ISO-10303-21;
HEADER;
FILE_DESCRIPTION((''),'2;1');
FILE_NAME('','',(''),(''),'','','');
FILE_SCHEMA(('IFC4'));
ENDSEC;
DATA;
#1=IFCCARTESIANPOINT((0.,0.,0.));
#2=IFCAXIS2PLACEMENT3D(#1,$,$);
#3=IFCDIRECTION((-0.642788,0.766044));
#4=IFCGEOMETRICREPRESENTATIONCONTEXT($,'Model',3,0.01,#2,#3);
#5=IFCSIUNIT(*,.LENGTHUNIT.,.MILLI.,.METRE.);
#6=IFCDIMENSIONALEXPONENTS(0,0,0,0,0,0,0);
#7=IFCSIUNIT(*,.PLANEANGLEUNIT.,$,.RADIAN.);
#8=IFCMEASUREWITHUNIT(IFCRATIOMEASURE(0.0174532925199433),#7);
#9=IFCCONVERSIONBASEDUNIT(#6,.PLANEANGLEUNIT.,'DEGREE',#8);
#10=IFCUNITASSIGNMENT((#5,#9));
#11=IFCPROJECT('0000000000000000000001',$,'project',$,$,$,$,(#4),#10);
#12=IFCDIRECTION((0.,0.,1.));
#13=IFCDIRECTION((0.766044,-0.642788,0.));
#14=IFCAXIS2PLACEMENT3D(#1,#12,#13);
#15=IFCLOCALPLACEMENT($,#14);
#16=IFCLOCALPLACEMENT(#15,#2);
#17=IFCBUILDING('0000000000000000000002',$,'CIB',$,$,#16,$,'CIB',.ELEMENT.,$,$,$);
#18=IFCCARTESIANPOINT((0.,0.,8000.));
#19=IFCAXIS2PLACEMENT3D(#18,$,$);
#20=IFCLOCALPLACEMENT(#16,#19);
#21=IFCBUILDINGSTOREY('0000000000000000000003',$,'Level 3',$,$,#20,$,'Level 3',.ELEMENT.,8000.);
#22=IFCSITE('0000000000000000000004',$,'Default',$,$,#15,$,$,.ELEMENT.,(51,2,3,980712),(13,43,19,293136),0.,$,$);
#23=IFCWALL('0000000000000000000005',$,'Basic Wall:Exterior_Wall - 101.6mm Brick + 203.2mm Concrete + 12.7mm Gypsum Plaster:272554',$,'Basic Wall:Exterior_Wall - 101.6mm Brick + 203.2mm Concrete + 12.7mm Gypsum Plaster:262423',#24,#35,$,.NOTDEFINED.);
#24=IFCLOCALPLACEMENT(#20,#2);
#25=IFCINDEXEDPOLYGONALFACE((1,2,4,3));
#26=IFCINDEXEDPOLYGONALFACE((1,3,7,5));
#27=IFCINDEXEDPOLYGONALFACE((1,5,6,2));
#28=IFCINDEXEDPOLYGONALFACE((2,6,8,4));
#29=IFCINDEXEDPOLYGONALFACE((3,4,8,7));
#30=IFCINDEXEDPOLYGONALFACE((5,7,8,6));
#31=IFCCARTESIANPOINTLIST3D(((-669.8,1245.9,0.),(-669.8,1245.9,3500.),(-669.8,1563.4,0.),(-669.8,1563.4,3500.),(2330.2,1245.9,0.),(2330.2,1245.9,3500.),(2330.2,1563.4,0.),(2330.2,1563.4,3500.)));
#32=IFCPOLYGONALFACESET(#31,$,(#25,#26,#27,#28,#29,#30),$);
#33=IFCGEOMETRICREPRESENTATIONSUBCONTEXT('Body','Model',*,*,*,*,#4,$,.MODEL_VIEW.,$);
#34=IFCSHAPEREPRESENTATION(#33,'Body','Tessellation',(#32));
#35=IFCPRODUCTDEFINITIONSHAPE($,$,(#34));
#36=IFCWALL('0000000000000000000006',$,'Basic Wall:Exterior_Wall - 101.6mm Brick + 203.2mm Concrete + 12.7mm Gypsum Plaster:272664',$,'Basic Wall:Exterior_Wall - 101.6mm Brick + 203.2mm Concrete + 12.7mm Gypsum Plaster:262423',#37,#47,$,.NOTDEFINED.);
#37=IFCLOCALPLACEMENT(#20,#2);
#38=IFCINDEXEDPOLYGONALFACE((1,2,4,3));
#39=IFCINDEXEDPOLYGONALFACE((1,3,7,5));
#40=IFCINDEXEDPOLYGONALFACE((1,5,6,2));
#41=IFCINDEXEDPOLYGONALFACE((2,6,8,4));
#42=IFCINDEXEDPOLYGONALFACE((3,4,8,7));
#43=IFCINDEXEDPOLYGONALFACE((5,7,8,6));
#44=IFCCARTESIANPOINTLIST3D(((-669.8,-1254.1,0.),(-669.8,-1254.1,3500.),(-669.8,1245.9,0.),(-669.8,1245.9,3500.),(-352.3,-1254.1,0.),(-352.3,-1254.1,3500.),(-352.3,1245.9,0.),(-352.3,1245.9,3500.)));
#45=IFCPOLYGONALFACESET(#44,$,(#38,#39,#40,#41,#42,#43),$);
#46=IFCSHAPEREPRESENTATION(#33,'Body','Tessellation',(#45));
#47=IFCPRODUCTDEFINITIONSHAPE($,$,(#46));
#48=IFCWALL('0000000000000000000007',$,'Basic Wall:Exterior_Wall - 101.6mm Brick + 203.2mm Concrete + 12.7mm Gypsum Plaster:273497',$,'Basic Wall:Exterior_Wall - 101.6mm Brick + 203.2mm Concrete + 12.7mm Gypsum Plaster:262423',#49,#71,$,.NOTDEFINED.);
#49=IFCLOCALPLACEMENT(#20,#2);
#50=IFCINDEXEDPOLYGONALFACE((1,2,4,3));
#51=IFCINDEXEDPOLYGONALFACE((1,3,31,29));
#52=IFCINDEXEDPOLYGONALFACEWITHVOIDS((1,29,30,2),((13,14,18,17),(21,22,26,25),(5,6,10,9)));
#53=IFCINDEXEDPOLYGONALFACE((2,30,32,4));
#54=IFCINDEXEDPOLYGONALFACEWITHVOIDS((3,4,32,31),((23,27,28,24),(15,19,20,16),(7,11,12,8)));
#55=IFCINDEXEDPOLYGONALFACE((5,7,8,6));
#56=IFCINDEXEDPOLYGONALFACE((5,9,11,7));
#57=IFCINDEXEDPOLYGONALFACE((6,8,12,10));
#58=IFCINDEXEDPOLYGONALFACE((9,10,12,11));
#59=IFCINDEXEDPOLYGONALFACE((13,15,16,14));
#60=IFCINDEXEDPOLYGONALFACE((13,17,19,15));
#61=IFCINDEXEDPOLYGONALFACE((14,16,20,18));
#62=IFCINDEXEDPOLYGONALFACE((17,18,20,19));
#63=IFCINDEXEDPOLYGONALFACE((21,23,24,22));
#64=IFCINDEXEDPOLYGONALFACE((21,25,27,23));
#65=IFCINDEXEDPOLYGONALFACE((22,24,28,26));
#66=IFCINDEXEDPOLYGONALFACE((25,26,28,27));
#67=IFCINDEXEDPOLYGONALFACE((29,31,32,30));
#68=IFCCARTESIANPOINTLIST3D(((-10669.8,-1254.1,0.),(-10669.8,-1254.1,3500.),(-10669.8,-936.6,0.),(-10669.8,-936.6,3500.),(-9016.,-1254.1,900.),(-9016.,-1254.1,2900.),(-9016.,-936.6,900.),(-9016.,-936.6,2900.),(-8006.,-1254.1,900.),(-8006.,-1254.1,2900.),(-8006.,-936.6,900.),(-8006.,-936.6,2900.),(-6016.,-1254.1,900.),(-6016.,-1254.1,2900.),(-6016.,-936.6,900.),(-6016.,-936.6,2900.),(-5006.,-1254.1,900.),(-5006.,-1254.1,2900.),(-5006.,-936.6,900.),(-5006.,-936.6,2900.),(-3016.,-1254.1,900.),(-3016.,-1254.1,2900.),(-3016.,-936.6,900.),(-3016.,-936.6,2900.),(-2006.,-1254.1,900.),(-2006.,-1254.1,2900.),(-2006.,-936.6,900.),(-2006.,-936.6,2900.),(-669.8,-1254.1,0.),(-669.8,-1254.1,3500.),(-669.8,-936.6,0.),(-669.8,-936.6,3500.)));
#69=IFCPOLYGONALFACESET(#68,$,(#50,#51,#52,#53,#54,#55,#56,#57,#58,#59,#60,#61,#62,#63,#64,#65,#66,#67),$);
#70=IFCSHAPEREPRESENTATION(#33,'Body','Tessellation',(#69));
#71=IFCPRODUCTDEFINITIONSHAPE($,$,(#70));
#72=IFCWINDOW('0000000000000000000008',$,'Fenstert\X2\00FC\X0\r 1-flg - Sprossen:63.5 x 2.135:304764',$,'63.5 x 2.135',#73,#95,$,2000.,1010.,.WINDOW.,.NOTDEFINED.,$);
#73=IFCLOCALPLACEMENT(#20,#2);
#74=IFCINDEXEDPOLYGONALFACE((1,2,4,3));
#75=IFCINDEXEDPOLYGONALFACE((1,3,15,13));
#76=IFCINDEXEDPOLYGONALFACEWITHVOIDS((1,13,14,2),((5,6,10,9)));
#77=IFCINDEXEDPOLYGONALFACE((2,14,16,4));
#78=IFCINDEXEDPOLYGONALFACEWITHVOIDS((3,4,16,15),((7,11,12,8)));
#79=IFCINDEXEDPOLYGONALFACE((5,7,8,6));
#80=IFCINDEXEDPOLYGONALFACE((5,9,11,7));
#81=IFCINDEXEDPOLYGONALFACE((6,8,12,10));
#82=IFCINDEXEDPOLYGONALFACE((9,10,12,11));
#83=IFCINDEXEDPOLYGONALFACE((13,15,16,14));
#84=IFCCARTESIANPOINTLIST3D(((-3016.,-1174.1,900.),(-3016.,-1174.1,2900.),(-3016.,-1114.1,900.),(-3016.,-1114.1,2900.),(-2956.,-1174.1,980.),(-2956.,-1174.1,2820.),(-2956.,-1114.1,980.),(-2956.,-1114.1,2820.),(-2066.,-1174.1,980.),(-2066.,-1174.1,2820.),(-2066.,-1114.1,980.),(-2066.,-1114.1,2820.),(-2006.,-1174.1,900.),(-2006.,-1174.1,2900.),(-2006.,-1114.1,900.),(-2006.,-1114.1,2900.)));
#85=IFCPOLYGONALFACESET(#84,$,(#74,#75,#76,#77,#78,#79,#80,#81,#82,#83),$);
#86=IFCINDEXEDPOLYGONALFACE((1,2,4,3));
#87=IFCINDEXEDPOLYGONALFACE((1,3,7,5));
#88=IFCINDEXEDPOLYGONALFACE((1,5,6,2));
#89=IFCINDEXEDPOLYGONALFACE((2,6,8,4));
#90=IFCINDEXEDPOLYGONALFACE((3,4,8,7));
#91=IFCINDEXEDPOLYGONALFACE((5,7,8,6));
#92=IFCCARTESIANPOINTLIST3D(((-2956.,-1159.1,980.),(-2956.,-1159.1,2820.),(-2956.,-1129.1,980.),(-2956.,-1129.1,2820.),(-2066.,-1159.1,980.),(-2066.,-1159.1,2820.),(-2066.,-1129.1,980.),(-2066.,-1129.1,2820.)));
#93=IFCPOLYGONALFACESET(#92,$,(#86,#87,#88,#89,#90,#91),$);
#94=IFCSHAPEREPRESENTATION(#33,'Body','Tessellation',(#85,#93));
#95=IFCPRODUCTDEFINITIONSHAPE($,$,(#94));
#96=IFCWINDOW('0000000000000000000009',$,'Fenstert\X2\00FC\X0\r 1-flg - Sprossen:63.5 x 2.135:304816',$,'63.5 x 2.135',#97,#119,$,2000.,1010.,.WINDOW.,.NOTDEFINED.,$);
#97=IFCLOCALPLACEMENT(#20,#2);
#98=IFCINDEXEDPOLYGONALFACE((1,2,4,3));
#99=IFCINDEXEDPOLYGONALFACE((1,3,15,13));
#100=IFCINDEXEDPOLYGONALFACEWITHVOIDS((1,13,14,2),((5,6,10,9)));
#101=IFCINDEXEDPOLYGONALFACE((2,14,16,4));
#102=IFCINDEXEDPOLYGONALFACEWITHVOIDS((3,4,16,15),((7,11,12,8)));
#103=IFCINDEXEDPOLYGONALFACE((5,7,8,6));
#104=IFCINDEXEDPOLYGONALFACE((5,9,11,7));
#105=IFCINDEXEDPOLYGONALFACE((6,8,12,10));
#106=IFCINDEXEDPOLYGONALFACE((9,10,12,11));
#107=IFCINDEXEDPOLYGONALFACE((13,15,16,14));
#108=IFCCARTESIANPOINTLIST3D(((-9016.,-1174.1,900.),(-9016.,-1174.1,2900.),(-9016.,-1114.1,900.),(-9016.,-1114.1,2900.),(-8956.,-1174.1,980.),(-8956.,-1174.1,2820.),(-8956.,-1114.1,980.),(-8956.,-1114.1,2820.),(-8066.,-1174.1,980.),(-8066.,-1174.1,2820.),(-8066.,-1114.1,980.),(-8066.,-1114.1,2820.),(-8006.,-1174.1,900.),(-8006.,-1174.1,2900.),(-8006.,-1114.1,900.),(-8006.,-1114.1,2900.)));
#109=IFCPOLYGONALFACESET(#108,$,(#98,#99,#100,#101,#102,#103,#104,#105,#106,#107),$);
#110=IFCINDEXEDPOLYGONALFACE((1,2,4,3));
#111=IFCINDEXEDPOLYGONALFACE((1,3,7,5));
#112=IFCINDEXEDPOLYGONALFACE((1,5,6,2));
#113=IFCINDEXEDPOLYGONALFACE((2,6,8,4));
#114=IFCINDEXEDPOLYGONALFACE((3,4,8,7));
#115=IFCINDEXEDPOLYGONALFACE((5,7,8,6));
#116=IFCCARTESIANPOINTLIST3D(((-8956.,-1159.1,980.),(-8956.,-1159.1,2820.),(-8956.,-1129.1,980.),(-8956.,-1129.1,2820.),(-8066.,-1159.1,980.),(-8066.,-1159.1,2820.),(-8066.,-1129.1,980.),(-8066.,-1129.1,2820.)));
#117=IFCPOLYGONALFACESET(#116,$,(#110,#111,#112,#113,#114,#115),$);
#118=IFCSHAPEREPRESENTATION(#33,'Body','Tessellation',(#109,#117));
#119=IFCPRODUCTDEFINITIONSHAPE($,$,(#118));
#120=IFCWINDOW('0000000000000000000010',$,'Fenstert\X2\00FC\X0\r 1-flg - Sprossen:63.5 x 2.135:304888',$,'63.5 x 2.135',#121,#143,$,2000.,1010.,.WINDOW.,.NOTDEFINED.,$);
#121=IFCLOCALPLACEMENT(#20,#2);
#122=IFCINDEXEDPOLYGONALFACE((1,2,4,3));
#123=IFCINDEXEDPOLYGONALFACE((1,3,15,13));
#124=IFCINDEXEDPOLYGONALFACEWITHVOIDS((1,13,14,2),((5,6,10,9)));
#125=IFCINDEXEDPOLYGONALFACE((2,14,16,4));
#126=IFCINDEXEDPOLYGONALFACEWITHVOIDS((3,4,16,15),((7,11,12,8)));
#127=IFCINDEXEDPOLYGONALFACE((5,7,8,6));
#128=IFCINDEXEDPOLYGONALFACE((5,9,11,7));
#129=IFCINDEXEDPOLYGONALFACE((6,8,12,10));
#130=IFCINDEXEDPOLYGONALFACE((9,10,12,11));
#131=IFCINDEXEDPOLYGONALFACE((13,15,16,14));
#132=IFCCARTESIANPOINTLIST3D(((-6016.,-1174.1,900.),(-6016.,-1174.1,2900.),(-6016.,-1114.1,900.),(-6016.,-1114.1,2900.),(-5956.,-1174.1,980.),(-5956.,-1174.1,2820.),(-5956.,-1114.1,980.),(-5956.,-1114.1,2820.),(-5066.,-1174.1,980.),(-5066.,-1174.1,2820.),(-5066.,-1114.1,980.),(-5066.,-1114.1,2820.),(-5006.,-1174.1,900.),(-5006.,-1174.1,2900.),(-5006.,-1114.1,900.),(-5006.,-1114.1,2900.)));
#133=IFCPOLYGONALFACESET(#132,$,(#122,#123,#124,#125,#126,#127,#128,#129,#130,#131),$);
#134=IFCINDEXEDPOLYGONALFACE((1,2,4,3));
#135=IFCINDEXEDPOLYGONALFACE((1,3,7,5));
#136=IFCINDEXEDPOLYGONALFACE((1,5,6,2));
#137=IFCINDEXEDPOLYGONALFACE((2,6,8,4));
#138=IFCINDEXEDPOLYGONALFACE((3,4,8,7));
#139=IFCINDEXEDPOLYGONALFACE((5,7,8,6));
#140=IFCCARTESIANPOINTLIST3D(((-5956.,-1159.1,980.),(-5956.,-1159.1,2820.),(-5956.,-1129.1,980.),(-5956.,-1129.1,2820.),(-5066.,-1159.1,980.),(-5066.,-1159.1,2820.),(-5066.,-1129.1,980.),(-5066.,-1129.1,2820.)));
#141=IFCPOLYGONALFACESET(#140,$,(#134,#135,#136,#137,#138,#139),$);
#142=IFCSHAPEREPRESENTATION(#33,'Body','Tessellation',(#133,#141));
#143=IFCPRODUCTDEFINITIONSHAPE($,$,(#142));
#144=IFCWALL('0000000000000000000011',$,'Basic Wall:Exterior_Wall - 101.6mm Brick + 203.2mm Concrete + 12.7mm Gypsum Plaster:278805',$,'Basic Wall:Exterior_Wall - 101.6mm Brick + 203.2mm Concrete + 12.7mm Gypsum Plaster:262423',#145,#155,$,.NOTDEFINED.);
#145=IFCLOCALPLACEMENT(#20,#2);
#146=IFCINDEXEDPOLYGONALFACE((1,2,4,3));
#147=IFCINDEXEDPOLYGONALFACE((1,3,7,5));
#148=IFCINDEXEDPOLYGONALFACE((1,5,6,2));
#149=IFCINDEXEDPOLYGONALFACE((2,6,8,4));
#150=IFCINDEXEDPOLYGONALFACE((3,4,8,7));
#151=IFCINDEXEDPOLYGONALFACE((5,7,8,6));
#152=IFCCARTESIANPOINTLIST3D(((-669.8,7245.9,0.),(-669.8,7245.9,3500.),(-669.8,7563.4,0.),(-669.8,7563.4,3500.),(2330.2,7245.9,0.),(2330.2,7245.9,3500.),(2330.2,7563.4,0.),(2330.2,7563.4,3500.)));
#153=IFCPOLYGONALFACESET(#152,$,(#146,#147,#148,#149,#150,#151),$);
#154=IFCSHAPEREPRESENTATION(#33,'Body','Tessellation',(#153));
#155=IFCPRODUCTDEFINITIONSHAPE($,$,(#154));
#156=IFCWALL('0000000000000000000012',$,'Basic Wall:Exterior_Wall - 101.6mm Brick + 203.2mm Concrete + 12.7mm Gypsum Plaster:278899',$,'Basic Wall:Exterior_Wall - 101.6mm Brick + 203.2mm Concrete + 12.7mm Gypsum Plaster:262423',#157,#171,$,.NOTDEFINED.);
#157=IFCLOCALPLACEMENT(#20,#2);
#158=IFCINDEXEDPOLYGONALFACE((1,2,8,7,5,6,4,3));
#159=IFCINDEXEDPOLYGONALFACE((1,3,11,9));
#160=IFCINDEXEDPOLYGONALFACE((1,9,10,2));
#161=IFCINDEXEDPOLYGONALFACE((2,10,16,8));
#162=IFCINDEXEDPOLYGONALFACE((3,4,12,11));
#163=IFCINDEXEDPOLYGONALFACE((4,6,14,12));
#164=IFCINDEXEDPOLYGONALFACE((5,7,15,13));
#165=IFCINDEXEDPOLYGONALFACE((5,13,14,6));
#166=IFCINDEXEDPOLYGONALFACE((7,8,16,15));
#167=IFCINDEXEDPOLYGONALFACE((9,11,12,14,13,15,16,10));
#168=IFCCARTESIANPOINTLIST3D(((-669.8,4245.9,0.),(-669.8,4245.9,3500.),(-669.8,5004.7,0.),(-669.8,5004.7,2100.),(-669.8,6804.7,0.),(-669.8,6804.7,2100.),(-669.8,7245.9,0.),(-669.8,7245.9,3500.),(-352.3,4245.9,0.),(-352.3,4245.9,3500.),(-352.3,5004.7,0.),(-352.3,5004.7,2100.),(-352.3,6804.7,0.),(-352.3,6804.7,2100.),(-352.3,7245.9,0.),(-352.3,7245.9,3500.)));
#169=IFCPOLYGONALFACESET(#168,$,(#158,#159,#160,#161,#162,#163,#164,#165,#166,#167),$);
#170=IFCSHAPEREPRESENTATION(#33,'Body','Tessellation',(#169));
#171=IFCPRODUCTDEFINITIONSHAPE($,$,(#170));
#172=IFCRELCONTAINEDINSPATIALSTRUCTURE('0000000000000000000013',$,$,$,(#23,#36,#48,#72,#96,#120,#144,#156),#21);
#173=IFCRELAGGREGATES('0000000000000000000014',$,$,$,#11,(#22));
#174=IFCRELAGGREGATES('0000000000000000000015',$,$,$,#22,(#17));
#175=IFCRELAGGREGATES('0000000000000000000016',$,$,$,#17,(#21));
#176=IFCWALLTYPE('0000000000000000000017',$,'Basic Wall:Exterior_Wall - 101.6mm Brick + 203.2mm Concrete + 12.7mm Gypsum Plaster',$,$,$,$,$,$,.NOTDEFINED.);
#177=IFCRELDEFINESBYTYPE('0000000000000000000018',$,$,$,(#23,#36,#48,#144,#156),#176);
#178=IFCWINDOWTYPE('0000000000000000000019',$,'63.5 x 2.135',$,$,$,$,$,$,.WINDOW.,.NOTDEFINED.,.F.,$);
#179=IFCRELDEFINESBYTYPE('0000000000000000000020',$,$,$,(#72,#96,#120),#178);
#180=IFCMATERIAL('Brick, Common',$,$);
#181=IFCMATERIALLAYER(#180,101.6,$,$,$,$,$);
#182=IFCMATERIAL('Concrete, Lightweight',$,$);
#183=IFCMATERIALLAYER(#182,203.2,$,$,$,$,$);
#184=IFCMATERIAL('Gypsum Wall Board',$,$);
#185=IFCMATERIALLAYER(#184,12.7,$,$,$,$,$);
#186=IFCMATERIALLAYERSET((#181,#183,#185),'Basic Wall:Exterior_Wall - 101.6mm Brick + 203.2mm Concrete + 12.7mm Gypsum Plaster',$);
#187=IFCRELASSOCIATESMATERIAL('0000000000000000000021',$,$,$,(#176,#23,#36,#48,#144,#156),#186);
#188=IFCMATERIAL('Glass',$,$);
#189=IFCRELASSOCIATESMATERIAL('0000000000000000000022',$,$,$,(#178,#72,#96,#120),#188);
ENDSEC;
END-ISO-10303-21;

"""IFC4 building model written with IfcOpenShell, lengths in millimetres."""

from ifc_helpers import new_model, entity, si_unit, converted_unit, direction, frame, frame_2d, origin, origin_2d_with_axis, place, context, subcontext, project, spatial, polyline, rectangle, outline, extrude, source, transform, mapped, material, layer, layer_set, layer_usage, type_object, type_shapes, element, fill, save


model = new_model("IFC4")

# Units and contexts
model_context = context("Model", 3, precision=0.01, world=origin(), true_north=direction((-0.642788, 0.766044)))
body_context = subcontext(model_context, "Body", "Model", "MODEL_VIEW")
ifc_project = project(units=[si_unit("LENGTHUNIT", "METRE", prefix="MILLI"), converted_unit("PLANEANGLEUNIT", "DEGREE", entity("IfcRatioMeasure", 0.0174532925199433), si_unit("PLANEANGLEUNIT", "RADIAN"), dimensions=[0, 0, 0, 0, 0, 0, 0])], contexts=[model_context])

# Site, building, storey
site_placement = place(None, frame((0.0, 0.0, 0.0), z_axis=(0.0, 0.0, 1.0), x_axis=(0.766044, -0.642788, 0.0)))
site = spatial("IfcSite", under=ifc_project, at=site_placement, Name="Default", CompositionType="ELEMENT", RefLatitude=(51, 2, 3, 980712), RefLongitude=(13, 43, 19, 293136), RefElevation=0.0)
building_placement = place(site_placement, origin())
building = spatial("IfcBuilding", under=site, at=building_placement, Name="CIB", LongName="CIB", CompositionType="ELEMENT")
storey_placement = place(building_placement, frame((0.0, 0.0, 8000.0)))
storey = spatial("IfcBuildingStorey", under=building, at=storey_placement, Name="Level 3", LongName="Level 3", CompositionType="ELEMENT", Elevation=8000.0)

# Walls
ifc_material_1 = material(Name="Brick, Common")
ifc_layer_1 = layer(ifc_material_1, 101.6)
ifc_material_2 = material(Name="Concrete, Lightweight")
ifc_layer_2 = layer(ifc_material_2, 203.2)
ifc_material_3 = material(Name="Gypsum Wall Board")
ifc_layer_3 = layer(ifc_material_3, 12.7)
ifc_layer_set_1 = layer_set([ifc_layer_1, ifc_layer_2, ifc_layer_3], Name="Basic Wall:Exterior_Wall - 101.6mm Brick + 203.2mm Concrete + 12.7mm Gypsum Plaster")
ifc_layer_usage_1 = layer_usage(ifc_layer_set_1, "AXIS2", "NEGATIVE", 158.8)
wall_type_1 = type_object("IfcWallType", Name="Basic Wall:Exterior_Wall - 101.6mm Brick + 203.2mm Concrete + 12.7mm Gypsum Plaster", PredefinedType="NOTDEFINED", material=ifc_layer_set_1)
wall_1_placement = place(storey_placement, frame((2330.2, 1404.7, 0.0), z_axis=(0.0, 0.0, 1.0), x_axis=(-1.0, 0.0, 0.0)))
element("IfcWall", 1, at=wall_1_placement, inside=storey, type_object=wall_type_1, material=ifc_layer_usage_1, Name="Basic Wall:Exterior_Wall - 101.6mm Brick + 203.2mm Concrete + 12.7mm Gypsum Plaster:272554", ObjectType="Basic Wall:Exterior_Wall - 101.6mm Brick + 203.2mm Concrete + 12.7mm Gypsum Plaster:262423", PredefinedType="NOTDEFINED", context=body_context, shape_type="SweptSolid", body=[
    extrude(rectangle(XDim=3000.0, YDim=317.5, at=frame_2d((1500.0, 0.0), x_axis=(-1.0, 0.0))), origin(), (0.0, 0.0, 1.0), 3500.0),
])
ifc_layer_usage_2 = layer_usage(ifc_layer_set_1, "AXIS2", "NEGATIVE", 158.8)
wall_2_placement = place(storey_placement, frame((-511.0, 1245.9, 0.0), z_axis=(0.0, 0.0, 1.0), x_axis=(0.0, -1.0, 0.0)))
element("IfcWall", 2, at=wall_2_placement, inside=storey, type_object=wall_type_1, material=ifc_layer_usage_2, Name="Basic Wall:Exterior_Wall - 101.6mm Brick + 203.2mm Concrete + 12.7mm Gypsum Plaster:272664", ObjectType="Basic Wall:Exterior_Wall - 101.6mm Brick + 203.2mm Concrete + 12.7mm Gypsum Plaster:262423", PredefinedType="NOTDEFINED", context=body_context, shape_type="SweptSolid", body=[
    extrude(rectangle(XDim=2500.0, YDim=317.5, at=frame_2d((1250.0, 0.0), x_axis=(-1.0, 0.0))), origin(), (0.0, 0.0, 1.0), 3500.0),
])

# Wall, openings, windows
ifc_layer_usage_3 = layer_usage(ifc_layer_set_1, "AXIS2", "NEGATIVE", 158.8)
wall_3_placement = place(storey_placement, frame((-669.8, -1095.3, 0.0), z_axis=(0.0, 0.0, 1.0), x_axis=(-1.0, 0.0, 0.0)))
wall_3 = element("IfcWall", 3, at=wall_3_placement, inside=storey, type_object=wall_type_1, material=ifc_layer_usage_3, Name="Basic Wall:Exterior_Wall - 101.6mm Brick + 203.2mm Concrete + 12.7mm Gypsum Plaster:273497", ObjectType="Basic Wall:Exterior_Wall - 101.6mm Brick + 203.2mm Concrete + 12.7mm Gypsum Plaster:262423", PredefinedType="NOTDEFINED", context=body_context, shape_type="SweptSolid", body=[
    extrude(rectangle(XDim=10000.0, YDim=317.5, at=frame_2d((5000.0, 0.0), x_axis=(-1.0, 0.0))), origin(), (0.0, 0.0, 1.0), 3500.0),
])
opening_1_placement = place(wall_3_placement, frame((2346.2, 158.7, 900.0)))
opening_1 = element("IfcOpeningElement", 4, at=opening_1_placement, cuts=wall_3, ObjectType="Opening", PredefinedType="OPENING", context=body_context, shape_type="SweptSolid", body=[
    extrude(rectangle(XDim=2000.0, YDim=1010.0, at=frame_2d((1000.0, 505.0), x_axis=(1.0, 0.0))), frame((0.0, 0.0, 0.0), z_axis=(0.0, -1.0, 0.0), x_axis=(0.0, 0.0, 1.0)), (0.0, 0.0, 1.0), 317.5),
])
opening_2_placement = place(wall_3_placement, frame((8346.2, 158.7, 900.0)))
opening_2 = element("IfcOpeningElement", 5, at=opening_2_placement, cuts=wall_3, ObjectType="Opening", PredefinedType="OPENING", context=body_context, shape_type="SweptSolid", body=[
    extrude(rectangle(XDim=2000.0, YDim=1010.0, at=frame_2d((1000.0, 505.0), x_axis=(1.0, 0.0))), frame((0.0, 0.0, 0.0), z_axis=(0.0, -1.0, 0.0), x_axis=(0.0, 0.0, 1.0)), (0.0, 0.0, 1.0), 317.5),
])
opening_3_placement = place(wall_3_placement, frame((5346.2, 158.7, 900.0)))
opening_3 = element("IfcOpeningElement", 6, at=opening_3_placement, cuts=wall_3, ObjectType="Opening", PredefinedType="OPENING", context=body_context, shape_type="SweptSolid", body=[
    extrude(rectangle(XDim=2000.0, YDim=1010.0, at=frame_2d((1000.0, 505.0), x_axis=(1.0, 0.0))), frame((0.0, 0.0, 0.0), z_axis=(0.0, -1.0, 0.0), x_axis=(0.0, 0.0, 1.0)), (0.0, 0.0, 1.0), 317.5),
])
ifc_material_4 = material(Name="Glass")
window_type = type_object("IfcWindowType", Name="63.5 x 2.135", ParameterTakesPrecedence=False, PartitioningType="NOTDEFINED", PredefinedType="WINDOW", material=ifc_material_4)
shared_shape_1 = source(origin(), body_context, "Body", "SweptSolid", [
    extrude(outline(polyline([(-1000.0, -505.0), (1000.0, -505.0), (1000.0, 505.0), (-1000.0, 505.0), (-1000.0, -505.0)]), holes=[polyline([(-920.0, -445.0), (-920.0, 445.0), (920.0, 445.0), (920.0, -445.0), (-920.0, -445.0)])]), frame((505.0, 177.5, 1000.0), z_axis=(0.0, 1.0, 0.0), x_axis=(0.0, 0.0, -1.0)), (0.0, 0.0, 1.0), 60.0),
    extrude(rectangle(XDim=30.0, YDim=890.0, at=origin_2d_with_axis()), frame((505.0, 207.5, 80.0), z_axis=(0.0, 0.0, 1.0), x_axis=(0.0, 1.0, 0.0)), (0.0, 0.0, 1.0), 1840.0),
])
type_shapes(window_type, [shared_shape_1])
window_1_placement = place(opening_1_placement, frame((-1010.0, -317.5, 0.0)))
window_1 = element("IfcWindow", 7, at=window_1_placement, inside=storey, type_object=window_type, material=ifc_material_4, Name="Fenstertür 1-flg - Sprossen:63.5 x 2.135:304764", ObjectType="63.5 x 2.135", OverallHeight=2000.0, OverallWidth=1010.0, PartitioningType="NOTDEFINED", PredefinedType="WINDOW", context=body_context, shape_type="MappedRepresentation", body=[
    mapped(shared_shape_1, transform((0.0, 0.0, 0.0), scale=1.0)),
])
fill(opening_1, window_1)
window_2_placement = place(opening_2_placement, frame((-1010.0, -317.5, 0.0)))
window_2 = element("IfcWindow", 8, at=window_2_placement, inside=storey, type_object=window_type, material=ifc_material_4, Name="Fenstertür 1-flg - Sprossen:63.5 x 2.135:304816", ObjectType="63.5 x 2.135", OverallHeight=2000.0, OverallWidth=1010.0, PartitioningType="NOTDEFINED", PredefinedType="WINDOW", context=body_context, shape_type="MappedRepresentation", body=[
    mapped(shared_shape_1, transform((0.0, 0.0, 0.0), scale=1.0)),
])
fill(opening_2, window_2)
window_3_placement = place(opening_3_placement, frame((-1010.0, -317.5, 0.0)))
window_3 = element("IfcWindow", 9, at=window_3_placement, inside=storey, type_object=window_type, material=ifc_material_4, Name="Fenstertür 1-flg - Sprossen:63.5 x 2.135:304888", ObjectType="63.5 x 2.135", OverallHeight=2000.0, OverallWidth=1010.0, PartitioningType="NOTDEFINED", PredefinedType="WINDOW", context=body_context, shape_type="MappedRepresentation", body=[
    mapped(shared_shape_1, transform((0.0, 0.0, 0.0), scale=1.0)),
])
fill(opening_3, window_3)

# Wall
ifc_layer_usage_4 = layer_usage(ifc_layer_set_1, "AXIS2", "NEGATIVE", 158.8)
wall_4_placement = place(storey_placement, frame((2330.2, 7404.7, 0.0), z_axis=(0.0, 0.0, 1.0), x_axis=(-1.0, 0.0, 0.0)))
element("IfcWall", 10, at=wall_4_placement, inside=storey, type_object=wall_type_1, material=ifc_layer_usage_4, Name="Basic Wall:Exterior_Wall - 101.6mm Brick + 203.2mm Concrete + 12.7mm Gypsum Plaster:278805", ObjectType="Basic Wall:Exterior_Wall - 101.6mm Brick + 203.2mm Concrete + 12.7mm Gypsum Plaster:262423", PredefinedType="NOTDEFINED", context=body_context, shape_type="SweptSolid", body=[
    extrude(rectangle(XDim=3000.0, YDim=317.5, at=frame_2d((1500.0, 0.0), x_axis=(-1.0, 0.0))), origin(), (0.0, 0.0, 1.0), 3500.0),
])

# Wall, opening
ifc_layer_usage_5 = layer_usage(ifc_layer_set_1, "AXIS2", "NEGATIVE", 158.8)
wall_5_placement = place(storey_placement, frame((-511.0, 7245.9, 0.0), z_axis=(0.0, 0.0, 1.0), x_axis=(0.0, -1.0, 0.0)))
wall_5 = element("IfcWall", 11, at=wall_5_placement, inside=storey, type_object=wall_type_1, material=ifc_layer_usage_5, Name="Basic Wall:Exterior_Wall - 101.6mm Brick + 203.2mm Concrete + 12.7mm Gypsum Plaster:278899", ObjectType="Basic Wall:Exterior_Wall - 101.6mm Brick + 203.2mm Concrete + 12.7mm Gypsum Plaster:262423", PredefinedType="NOTDEFINED", context=body_context, shape_type="SweptSolid", body=[
    extrude(rectangle(XDim=3000.0, YDim=317.5, at=frame_2d((1500.0, 0.0), x_axis=(-1.0, 0.0))), origin(), (0.0, 0.0, 1.0), 3500.0),
])
opening_4_placement = place(wall_5_placement, frame((2241.3, 158.7, 0.0)))
element("IfcOpeningElement", 12, at=opening_4_placement, cuts=wall_5, ObjectType="Opening", PredefinedType="OPENING", context=body_context, shape_type="SweptSolid", body=[
    extrude(rectangle(XDim=2100.0, YDim=1800.0, at=frame_2d((1050.0, 900.0), x_axis=(1.0, 0.0))), frame((0.0, 0.0, 0.0), z_axis=(0.0, -1.0, 0.0), x_axis=(0.0, 0.0, 1.0)), (0.0, 0.0, 1.0), 317.5),
])

save(model, "model.ifc")
